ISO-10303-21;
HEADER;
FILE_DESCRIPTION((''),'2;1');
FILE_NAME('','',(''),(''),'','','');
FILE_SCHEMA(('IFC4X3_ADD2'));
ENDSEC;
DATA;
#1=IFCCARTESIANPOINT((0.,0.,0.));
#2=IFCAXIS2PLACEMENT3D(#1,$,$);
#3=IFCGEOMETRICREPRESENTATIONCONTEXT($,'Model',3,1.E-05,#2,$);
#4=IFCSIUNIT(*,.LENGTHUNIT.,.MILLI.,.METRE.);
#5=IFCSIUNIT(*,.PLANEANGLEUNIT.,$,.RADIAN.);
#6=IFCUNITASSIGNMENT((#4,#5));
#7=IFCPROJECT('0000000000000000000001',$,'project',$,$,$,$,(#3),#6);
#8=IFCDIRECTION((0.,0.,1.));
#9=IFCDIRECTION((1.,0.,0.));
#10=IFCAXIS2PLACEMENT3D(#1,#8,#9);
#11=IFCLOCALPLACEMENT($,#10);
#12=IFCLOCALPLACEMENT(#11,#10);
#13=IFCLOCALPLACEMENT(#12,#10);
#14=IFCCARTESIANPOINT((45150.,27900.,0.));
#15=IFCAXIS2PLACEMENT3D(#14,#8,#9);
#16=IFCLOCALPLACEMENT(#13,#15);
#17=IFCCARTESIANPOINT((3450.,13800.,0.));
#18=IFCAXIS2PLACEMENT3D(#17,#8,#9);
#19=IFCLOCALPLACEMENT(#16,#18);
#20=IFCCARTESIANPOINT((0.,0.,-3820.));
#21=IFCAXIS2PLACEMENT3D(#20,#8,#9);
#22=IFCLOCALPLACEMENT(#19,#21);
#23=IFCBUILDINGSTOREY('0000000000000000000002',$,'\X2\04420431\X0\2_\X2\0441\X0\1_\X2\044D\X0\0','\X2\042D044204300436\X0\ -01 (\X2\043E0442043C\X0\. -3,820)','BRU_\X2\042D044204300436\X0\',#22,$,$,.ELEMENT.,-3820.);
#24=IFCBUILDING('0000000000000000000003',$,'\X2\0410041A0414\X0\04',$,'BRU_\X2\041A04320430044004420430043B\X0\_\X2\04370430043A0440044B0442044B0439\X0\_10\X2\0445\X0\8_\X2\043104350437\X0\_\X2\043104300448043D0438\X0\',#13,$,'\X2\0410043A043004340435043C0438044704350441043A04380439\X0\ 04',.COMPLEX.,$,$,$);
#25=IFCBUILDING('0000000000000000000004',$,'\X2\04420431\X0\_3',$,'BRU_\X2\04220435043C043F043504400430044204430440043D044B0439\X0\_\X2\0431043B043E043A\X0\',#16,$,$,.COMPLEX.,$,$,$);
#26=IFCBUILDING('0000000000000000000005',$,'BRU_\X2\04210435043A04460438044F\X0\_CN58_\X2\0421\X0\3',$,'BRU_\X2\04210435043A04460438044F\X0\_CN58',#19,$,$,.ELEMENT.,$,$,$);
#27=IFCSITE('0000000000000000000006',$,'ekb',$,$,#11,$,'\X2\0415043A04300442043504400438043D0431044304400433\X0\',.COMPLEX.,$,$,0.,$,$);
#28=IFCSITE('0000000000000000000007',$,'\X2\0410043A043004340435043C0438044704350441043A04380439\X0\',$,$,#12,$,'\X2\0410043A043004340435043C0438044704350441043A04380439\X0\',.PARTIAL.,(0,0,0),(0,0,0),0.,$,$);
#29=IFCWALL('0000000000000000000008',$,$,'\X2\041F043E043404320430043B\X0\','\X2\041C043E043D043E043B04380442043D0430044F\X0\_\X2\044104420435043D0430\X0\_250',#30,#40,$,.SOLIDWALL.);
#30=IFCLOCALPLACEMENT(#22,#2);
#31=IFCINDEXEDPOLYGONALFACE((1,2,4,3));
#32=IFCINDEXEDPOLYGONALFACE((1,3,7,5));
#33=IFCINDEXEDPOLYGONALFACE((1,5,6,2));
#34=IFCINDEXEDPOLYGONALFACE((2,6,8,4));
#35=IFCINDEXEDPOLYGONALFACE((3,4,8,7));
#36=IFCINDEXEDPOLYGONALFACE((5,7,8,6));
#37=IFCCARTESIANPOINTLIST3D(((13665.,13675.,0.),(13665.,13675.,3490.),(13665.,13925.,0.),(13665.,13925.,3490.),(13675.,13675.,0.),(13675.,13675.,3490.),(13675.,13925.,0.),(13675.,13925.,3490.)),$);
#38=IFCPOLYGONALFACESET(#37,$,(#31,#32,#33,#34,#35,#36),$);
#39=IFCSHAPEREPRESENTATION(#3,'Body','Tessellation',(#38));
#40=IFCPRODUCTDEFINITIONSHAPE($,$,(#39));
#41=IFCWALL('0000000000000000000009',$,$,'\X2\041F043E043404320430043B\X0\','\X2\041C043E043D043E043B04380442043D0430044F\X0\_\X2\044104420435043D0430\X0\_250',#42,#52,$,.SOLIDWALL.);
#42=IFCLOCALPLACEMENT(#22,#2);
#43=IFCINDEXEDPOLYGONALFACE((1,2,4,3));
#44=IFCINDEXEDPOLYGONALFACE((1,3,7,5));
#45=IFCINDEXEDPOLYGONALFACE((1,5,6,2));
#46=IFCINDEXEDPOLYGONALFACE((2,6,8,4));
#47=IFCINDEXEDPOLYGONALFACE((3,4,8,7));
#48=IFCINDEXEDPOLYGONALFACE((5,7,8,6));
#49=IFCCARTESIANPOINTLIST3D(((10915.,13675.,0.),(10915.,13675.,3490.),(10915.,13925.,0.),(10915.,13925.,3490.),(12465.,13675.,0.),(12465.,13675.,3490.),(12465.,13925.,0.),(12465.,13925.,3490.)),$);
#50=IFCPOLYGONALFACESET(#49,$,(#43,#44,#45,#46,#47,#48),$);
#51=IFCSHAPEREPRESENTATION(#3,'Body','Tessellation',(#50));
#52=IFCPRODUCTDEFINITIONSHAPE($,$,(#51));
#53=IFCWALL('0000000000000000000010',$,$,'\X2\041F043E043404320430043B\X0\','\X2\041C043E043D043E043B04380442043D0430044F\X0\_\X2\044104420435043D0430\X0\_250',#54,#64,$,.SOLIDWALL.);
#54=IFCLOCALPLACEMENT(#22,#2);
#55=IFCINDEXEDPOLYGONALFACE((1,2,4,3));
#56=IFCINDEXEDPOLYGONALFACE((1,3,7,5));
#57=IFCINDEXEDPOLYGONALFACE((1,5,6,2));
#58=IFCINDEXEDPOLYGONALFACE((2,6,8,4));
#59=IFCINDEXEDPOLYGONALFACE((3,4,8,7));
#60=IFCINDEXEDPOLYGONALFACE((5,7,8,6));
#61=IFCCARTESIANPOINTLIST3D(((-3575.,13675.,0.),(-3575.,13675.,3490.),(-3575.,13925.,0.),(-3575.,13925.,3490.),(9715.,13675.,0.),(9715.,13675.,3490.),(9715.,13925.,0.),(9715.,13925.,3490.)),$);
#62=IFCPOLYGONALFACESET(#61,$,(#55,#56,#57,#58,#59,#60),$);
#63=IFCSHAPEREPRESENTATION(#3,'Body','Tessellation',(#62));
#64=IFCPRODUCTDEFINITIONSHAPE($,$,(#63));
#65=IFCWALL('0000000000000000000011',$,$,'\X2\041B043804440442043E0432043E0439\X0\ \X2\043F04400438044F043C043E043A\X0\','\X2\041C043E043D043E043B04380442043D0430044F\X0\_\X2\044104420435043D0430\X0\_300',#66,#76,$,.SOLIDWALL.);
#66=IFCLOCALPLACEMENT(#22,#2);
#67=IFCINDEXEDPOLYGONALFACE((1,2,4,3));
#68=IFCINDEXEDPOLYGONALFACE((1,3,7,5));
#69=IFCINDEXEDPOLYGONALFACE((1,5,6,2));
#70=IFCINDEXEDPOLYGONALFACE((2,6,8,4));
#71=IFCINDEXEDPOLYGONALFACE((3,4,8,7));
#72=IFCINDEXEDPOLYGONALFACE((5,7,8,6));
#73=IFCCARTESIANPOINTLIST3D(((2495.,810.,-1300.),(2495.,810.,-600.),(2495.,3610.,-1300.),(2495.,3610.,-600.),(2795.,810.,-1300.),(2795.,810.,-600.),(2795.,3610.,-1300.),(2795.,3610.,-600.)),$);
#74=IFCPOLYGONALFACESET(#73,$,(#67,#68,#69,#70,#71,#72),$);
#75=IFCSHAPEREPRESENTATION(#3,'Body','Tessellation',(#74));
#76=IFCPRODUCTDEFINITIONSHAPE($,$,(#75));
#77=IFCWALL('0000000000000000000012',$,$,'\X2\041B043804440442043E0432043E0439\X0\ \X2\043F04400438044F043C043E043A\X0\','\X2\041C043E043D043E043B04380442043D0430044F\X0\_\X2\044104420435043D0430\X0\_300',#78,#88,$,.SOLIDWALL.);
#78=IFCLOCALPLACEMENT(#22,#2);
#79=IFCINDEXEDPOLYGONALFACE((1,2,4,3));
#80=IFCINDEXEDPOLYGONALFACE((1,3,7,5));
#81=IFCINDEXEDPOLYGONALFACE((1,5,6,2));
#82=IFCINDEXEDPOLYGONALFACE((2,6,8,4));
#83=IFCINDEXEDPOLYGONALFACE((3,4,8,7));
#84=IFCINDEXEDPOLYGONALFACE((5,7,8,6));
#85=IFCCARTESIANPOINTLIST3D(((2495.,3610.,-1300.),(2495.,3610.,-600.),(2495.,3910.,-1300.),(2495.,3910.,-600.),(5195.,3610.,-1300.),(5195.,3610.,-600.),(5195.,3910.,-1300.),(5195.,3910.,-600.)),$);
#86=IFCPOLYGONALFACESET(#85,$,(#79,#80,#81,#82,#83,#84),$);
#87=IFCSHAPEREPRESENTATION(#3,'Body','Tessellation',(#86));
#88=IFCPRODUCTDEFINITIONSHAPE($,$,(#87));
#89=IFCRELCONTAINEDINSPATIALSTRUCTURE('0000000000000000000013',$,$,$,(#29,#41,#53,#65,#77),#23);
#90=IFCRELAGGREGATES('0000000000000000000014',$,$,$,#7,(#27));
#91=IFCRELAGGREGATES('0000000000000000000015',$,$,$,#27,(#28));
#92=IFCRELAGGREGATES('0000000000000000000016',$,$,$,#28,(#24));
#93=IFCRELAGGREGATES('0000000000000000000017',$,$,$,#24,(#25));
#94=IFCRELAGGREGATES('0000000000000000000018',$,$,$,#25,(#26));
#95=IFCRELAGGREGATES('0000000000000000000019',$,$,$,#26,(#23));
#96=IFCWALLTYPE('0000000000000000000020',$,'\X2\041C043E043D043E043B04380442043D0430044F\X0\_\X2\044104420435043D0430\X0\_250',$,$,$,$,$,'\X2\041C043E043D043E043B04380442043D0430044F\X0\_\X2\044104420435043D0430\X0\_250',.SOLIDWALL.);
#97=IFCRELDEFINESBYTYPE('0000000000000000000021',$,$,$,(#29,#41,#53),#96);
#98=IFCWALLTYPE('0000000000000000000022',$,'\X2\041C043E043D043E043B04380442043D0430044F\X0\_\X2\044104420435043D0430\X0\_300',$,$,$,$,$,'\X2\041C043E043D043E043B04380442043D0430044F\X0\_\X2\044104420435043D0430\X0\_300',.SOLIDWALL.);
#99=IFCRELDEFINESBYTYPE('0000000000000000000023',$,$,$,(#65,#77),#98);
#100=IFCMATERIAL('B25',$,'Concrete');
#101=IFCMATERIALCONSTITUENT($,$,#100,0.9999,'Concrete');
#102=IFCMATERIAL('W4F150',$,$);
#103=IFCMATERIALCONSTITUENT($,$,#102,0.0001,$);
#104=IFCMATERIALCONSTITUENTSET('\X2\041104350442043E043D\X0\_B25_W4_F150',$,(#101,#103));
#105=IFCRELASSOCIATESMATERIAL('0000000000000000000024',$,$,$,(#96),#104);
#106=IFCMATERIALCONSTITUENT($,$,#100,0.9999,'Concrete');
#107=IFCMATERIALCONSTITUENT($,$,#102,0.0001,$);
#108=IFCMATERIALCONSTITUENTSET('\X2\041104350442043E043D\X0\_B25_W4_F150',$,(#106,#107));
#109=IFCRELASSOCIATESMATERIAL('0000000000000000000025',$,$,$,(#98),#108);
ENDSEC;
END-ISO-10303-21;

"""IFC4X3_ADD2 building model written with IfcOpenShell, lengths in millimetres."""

from ifc_helpers import new_model, si_unit, frame, origin, origin_with_axes, origin_2d_with_axis, place, context, project, spatial, rectangle, extrude, material, constituent, constituent_set, type_object, element, save


model = new_model("IFC4X3_ADD2")

# Units and contexts
model_context = context("Model", 3, precision=1e-05, world=origin())
ifc_project = project(units=[si_unit("LENGTHUNIT", "METRE", prefix="MILLI"), si_unit("PLANEANGLEUNIT", "RADIAN")], contexts=[model_context])

# Sites, buildings, storey
site_1_placement = place(None, origin_with_axes())
site_1 = spatial("IfcSite", under=ifc_project, at=site_1_placement, Name="ekb", LongName="Екатеринбург", CompositionType="COMPLEX", RefElevation=0.0)
site_2_placement = place(site_1_placement, origin_with_axes())
site_2 = spatial("IfcSite", under=site_1, at=site_2_placement, Name="Академический", LongName="Академический", CompositionType="PARTIAL", RefLatitude=(0, 0, 0), RefLongitude=(0, 0, 0), RefElevation=0.0)
building_1_placement = place(site_2_placement, origin_with_axes())
building_1 = spatial("IfcBuilding", under=site_2, at=building_1_placement, Name="АКД04", ObjectType="BRU_Квартал_закрытый_10х8_без_башни", LongName="Академический 04", CompositionType="COMPLEX")
building_2_placement = place(building_1_placement, frame((45150.0, 27900.0, 0.0), z_axis=(0.0, 0.0, 1.0), x_axis=(1.0, 0.0, 0.0)))
building_2 = spatial("IfcBuilding", under=building_1, at=building_2_placement, Name="тб_3", ObjectType="BRU_Температурный_блок", CompositionType="COMPLEX")
building_3_placement = place(building_2_placement, frame((3450.0, 13800.0, 0.0), z_axis=(0.0, 0.0, 1.0), x_axis=(1.0, 0.0, 0.0)))
building_3 = spatial("IfcBuilding", under=building_2, at=building_3_placement, Name="BRU_Секция_CN58_С3", ObjectType="BRU_Секция_CN58", CompositionType="ELEMENT")
storey_placement = place(building_3_placement, frame((0.0, 0.0, -3820.0), z_axis=(0.0, 0.0, 1.0), x_axis=(1.0, 0.0, 0.0)))
storey = spatial("IfcBuildingStorey", under=building_3, at=storey_placement, Name="тб2_с1_э0", Description="Этаж -01 (отм. -3,820)", ObjectType="BRU_Этаж", CompositionType="ELEMENT", Elevation=-3820.0)

# Shared definitions
ifc_material_1 = material(Name="B25", Category="Concrete")
ifc_material_2 = material(Name="W4F150")

# Walls
ifc_constituent_1 = constituent(ifc_material_1, Category="Concrete", fraction=0.9999)
ifc_constituent_2 = constituent(ifc_material_2, fraction=0.0001)
ifc_constituent_set_1 = constituent_set(constituents=[ifc_constituent_1, ifc_constituent_2], Name="Бетон_B25_W4_F150")
wall_type_1 = type_object("IfcWallType", Name="Монолитная_стена_250", ElementType="Монолитная_стена_250", PredefinedType="SOLIDWALL", material=ifc_constituent_set_1)
wall_1_placement = place(storey_placement, frame((13675.0, 13800.0, 0.0), z_axis=(0.0, 0.0, 1.0), x_axis=(-1.0, 0.0, 0.0)))
element("IfcWall", 1, at=wall_1_placement, inside=storey, type_object=wall_type_1, Description="Подвал", ObjectType="Монолитная_стена_250", PredefinedType="SOLIDWALL", context=model_context, shape_type="SweptSolid", body=[
    extrude(rectangle(XDim=10.0, YDim=250.0, at=origin_2d_with_axis()), frame((5.0, 0.0, 0.0), z_axis=(0.0, 0.0, 1.0), x_axis=(1.0, 0.0, 0.0)), (0.0, 0.0, 1.0), 3490.0),
])
wall_2_placement = place(storey_placement, frame((12465.0, 13800.0, 0.0), z_axis=(0.0, 0.0, 1.0), x_axis=(-1.0, 0.0, 0.0)))
element("IfcWall", 2, at=wall_2_placement, inside=storey, type_object=wall_type_1, Description="Подвал", ObjectType="Монолитная_стена_250", PredefinedType="SOLIDWALL", context=model_context, shape_type="SweptSolid", body=[
    extrude(rectangle(XDim=1550.0, YDim=250.0, at=origin_2d_with_axis()), frame((775.0, 0.0, 0.0), z_axis=(0.0, 0.0, 1.0), x_axis=(1.0, 0.0, 0.0)), (0.0, 0.0, 1.0), 3490.0),
])
wall_3_placement = place(storey_placement, frame((9715.0, 13800.0, 0.0), z_axis=(0.0, 0.0, 1.0), x_axis=(-1.0, 0.0, 0.0)))
element("IfcWall", 3, at=wall_3_placement, inside=storey, type_object=wall_type_1, Description="Подвал", ObjectType="Монолитная_стена_250", PredefinedType="SOLIDWALL", context=model_context, shape_type="SweptSolid", body=[
    extrude(rectangle(XDim=13290.0, YDim=250.0, at=origin_2d_with_axis()), frame((6645.0, 0.0, 0.0), z_axis=(0.0, 0.0, 1.0), x_axis=(1.0, 0.0, 0.0)), (0.0, 0.0, 1.0), 3490.0),
])
ifc_constituent_3 = constituent(ifc_material_1, Category="Concrete", fraction=0.9999)
ifc_constituent_4 = constituent(ifc_material_2, fraction=0.0001)
ifc_constituent_set_2 = constituent_set(constituents=[ifc_constituent_3, ifc_constituent_4], Name="Бетон_B25_W4_F150")
wall_type_2 = type_object("IfcWallType", Name="Монолитная_стена_300", ElementType="Монолитная_стена_300", PredefinedType="SOLIDWALL", material=ifc_constituent_set_2)
wall_4_placement = place(storey_placement, frame((2645.0, 3610.0, -1300.0), z_axis=(0.0, 0.0, 1.0), x_axis=(0.0, -1.0, 0.0)))
element("IfcWall", 4, at=wall_4_placement, inside=storey, type_object=wall_type_2, Description="Лифтовой приямок", ObjectType="Монолитная_стена_300", PredefinedType="SOLIDWALL", context=model_context, shape_type="SweptSolid", body=[
    extrude(rectangle(XDim=2800.0, YDim=300.0, at=origin_2d_with_axis()), frame((1400.0, 0.0, 0.0), z_axis=(0.0, 0.0, 1.0), x_axis=(1.0, 0.0, 0.0)), (0.0, 0.0, 1.0), 700.0),
])
wall_5_placement = place(storey_placement, frame((5195.0, 3760.0, -1300.0), z_axis=(0.0, 0.0, 1.0), x_axis=(-1.0, 0.0, 0.0)))
element("IfcWall", 5, at=wall_5_placement, inside=storey, type_object=wall_type_2, Description="Лифтовой приямок", ObjectType="Монолитная_стена_300", PredefinedType="SOLIDWALL", context=model_context, shape_type="SweptSolid", body=[
    extrude(rectangle(XDim=2700.0, YDim=300.0, at=origin_2d_with_axis()), frame((1350.0, 0.0, 0.0), z_axis=(0.0, 0.0, 1.0), x_axis=(1.0, 0.0, 0.0)), (0.0, 0.0, 1.0), 700.0),
])

save(model, "model.ifc")
